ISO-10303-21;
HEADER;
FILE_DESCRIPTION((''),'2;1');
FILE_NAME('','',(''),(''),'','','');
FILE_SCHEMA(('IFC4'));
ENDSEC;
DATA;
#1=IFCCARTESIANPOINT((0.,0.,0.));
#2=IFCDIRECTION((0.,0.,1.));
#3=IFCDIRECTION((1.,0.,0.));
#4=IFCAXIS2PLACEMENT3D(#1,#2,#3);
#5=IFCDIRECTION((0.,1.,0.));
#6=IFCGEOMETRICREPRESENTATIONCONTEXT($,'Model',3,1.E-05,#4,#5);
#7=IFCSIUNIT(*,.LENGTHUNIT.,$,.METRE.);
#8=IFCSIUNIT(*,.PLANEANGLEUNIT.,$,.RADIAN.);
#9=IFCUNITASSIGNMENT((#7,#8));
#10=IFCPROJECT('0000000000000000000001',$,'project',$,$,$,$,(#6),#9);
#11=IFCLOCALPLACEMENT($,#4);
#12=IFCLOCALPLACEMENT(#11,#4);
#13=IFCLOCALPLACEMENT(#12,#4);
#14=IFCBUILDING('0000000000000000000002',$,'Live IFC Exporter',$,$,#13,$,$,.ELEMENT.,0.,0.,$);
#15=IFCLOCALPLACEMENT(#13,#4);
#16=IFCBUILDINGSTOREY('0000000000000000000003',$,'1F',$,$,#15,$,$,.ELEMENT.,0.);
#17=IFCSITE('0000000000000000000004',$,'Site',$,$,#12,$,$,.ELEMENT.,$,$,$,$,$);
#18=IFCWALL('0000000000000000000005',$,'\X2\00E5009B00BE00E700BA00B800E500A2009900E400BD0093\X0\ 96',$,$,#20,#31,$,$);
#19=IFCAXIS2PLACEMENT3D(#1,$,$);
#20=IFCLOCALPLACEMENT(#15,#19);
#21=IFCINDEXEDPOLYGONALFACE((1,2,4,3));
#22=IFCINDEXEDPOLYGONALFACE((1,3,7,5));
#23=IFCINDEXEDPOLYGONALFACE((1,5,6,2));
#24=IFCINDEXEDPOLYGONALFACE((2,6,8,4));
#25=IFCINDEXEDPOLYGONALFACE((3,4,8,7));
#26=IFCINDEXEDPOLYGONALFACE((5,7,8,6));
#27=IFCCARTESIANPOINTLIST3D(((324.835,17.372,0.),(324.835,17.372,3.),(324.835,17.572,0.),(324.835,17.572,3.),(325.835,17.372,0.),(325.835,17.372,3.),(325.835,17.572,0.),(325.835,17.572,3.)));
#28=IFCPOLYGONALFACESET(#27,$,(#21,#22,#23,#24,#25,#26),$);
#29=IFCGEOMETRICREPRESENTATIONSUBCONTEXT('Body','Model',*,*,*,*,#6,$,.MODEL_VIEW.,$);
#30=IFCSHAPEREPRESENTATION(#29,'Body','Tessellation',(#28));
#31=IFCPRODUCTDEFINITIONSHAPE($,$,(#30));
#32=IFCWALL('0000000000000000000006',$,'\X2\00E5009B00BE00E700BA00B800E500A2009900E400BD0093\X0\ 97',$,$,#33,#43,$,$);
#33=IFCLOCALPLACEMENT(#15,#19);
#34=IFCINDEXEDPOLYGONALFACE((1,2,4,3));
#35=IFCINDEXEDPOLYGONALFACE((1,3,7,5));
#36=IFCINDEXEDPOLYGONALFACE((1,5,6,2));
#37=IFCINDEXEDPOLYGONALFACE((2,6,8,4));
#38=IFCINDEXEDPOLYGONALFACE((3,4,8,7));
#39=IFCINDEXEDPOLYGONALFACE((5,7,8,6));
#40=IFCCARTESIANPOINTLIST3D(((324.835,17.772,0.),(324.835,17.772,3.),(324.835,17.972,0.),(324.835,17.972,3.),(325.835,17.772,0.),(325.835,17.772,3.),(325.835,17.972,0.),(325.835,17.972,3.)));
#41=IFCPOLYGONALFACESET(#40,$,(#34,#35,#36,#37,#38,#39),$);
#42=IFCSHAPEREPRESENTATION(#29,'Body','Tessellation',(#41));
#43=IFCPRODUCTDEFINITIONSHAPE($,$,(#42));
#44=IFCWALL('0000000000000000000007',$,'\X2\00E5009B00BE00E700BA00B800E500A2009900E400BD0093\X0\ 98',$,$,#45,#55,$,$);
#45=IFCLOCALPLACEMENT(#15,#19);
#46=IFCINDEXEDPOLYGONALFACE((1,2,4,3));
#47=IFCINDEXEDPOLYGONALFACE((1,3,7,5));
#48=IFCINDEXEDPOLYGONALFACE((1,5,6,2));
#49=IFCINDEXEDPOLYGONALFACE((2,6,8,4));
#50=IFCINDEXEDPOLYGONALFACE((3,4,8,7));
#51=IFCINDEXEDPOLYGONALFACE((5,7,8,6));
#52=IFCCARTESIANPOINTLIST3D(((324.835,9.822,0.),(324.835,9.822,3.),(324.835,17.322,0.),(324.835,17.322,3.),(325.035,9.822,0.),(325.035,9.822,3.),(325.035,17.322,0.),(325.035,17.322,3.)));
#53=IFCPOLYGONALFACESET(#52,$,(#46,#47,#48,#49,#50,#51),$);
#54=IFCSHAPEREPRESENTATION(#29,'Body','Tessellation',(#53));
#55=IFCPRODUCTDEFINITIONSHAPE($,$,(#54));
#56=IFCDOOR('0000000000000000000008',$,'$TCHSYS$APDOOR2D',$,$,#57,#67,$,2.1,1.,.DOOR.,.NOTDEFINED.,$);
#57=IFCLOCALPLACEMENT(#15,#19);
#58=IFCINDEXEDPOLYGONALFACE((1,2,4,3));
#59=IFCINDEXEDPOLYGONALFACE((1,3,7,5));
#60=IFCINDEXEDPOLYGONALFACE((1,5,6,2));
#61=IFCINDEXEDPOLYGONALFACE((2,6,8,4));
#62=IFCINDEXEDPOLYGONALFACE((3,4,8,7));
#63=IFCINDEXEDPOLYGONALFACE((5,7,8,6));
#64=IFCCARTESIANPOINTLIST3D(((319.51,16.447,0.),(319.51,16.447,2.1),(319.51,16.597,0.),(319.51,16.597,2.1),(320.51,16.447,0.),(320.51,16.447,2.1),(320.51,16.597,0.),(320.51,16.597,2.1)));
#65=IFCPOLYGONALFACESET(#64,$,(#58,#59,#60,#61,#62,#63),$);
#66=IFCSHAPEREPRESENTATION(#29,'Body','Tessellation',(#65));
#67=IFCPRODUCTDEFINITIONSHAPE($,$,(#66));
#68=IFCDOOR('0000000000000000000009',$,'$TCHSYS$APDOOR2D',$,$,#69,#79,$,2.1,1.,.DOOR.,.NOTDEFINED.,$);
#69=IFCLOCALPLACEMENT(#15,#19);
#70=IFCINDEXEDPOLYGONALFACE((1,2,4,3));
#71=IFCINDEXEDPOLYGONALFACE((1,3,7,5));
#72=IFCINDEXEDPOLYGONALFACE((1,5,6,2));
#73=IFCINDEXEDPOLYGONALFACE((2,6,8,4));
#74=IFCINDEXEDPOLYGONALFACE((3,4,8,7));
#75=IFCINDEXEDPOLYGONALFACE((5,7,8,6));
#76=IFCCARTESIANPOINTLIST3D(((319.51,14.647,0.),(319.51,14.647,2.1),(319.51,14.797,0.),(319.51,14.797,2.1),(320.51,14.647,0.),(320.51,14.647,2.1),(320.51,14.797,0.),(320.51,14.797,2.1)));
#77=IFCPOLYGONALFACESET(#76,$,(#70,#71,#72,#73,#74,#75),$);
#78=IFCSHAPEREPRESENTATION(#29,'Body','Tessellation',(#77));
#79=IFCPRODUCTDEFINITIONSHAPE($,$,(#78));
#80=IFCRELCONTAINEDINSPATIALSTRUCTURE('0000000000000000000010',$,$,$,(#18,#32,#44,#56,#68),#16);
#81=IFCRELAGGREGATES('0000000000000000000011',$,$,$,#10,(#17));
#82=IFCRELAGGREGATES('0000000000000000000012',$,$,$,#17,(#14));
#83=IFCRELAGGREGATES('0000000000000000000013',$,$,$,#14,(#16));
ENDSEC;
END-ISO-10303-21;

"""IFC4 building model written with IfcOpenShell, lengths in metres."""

from ifc_helpers import new_model, si_unit, direction, frame, frame_2d, origin_with_axes, place, context, subcontext, project, spatial, rectangle, extrude, element, save


model = new_model("IFC4")

# Units and contexts
model_context = context("Model", 3, precision=1e-05, world=origin_with_axes(), true_north=direction((0.0, 1.0, 0.0)))
body_context = subcontext(model_context, "Body", "Model", "MODEL_VIEW")
ifc_project = project(units=[si_unit("LENGTHUNIT", "METRE"), si_unit("PLANEANGLEUNIT", "RADIAN")], contexts=[model_context])

# Site, building, storey
placement = place(None, origin_with_axes())
site_placement = place(placement, origin_with_axes())
site = spatial("IfcSite", under=ifc_project, at=site_placement, Name="Site", CompositionType="ELEMENT")
building_placement = place(site_placement, origin_with_axes())
building = spatial("IfcBuilding", under=site, at=building_placement, Name="Live IFC Exporter", CompositionType="ELEMENT", ElevationOfRefHeight=0.0, ElevationOfTerrain=0.0)
storey_placement = place(building_placement, origin_with_axes())
storey = spatial("IfcBuildingStorey", under=building, at=storey_placement, Name="1F", CompositionType="ELEMENT", Elevation=0.0)

# Walls
for number, where, z_axis, x_axis, name in (
    (1, (325.335, 17.472, 0.0), (0.0, 0.0, 1.0), (1.0, 0.0, 0.0), "å\u009b¾çº¸å¢\u0099ä½\u0093 96"),
    (2, (325.335, 17.872, 0.0), (0.0, 0.0, 1.0), (1.0, 0.0, 0.0), "å\u009b¾çº¸å¢\u0099ä½\u0093 97"),
):
    element("IfcWall", number, at=place(storey_placement, frame(where, z_axis=z_axis, x_axis=x_axis)), inside=storey, Name=name, context=body_context, shape_type="SweptSolid", body=[
        extrude(rectangle(XDim=1.0, YDim=0.2, at=frame_2d((0.0, 0.0), x_axis=(1.0, 0.0, 0.0))), frame((0.0, 0.0, 0.0), z_axis=(0.0, 0.0, 1.0)), (0.0, 0.0, 1.0), 3.0),
    ])
wall_1_placement = place(storey_placement, frame((324.935, 13.572, 0.0), z_axis=(0.0, 0.0, 1.0), x_axis=(0.0, 1.0, 0.0)))
element("IfcWall", 3, at=wall_1_placement, inside=storey, Name="å\u009b¾çº¸å¢\u0099ä½\u0093 98", context=body_context, shape_type="SweptSolid", body=[
    extrude(rectangle(XDim=7.5, YDim=0.2, at=frame_2d((0.0, 0.0), x_axis=(1.0, 0.0, 0.0))), frame((0.0, 0.0, 0.0), z_axis=(0.0, 0.0, 1.0)), (0.0, 0.0, 1.0), 3.0),
])

# Doors
for number, where, z_axis, x_axis, name in (
    (4, (320.01, 16.522, 0.0), (0.0, 0.0, 1.0), (1.0, 0.0, 0.0), "$TCHSYS$APDOOR2D"),
    (5, (320.01, 14.722, 0.0), (0.0, 0.0, 1.0), (1.0, 0.0, 0.0), "$TCHSYS$APDOOR2D"),
):
    element("IfcDoor", number, at=place(storey_placement, frame(where, z_axis=z_axis, x_axis=x_axis)), inside=storey, Name=name, OperationType="NOTDEFINED", OverallHeight=2.1, OverallWidth=1.0, PredefinedType="DOOR", context=body_context, shape_type="SweptSolid", body=[
        extrude(rectangle(XDim=1.0, YDim=0.15, at=frame_2d((0.0, 0.0), x_axis=(1.0, 0.0, 0.0))), frame((0.0, 0.0, 0.0), z_axis=(0.0, 0.0, 1.0)), (0.0, 0.0, 1.0), 2.1),
    ])

save(model, "model.ifc")
